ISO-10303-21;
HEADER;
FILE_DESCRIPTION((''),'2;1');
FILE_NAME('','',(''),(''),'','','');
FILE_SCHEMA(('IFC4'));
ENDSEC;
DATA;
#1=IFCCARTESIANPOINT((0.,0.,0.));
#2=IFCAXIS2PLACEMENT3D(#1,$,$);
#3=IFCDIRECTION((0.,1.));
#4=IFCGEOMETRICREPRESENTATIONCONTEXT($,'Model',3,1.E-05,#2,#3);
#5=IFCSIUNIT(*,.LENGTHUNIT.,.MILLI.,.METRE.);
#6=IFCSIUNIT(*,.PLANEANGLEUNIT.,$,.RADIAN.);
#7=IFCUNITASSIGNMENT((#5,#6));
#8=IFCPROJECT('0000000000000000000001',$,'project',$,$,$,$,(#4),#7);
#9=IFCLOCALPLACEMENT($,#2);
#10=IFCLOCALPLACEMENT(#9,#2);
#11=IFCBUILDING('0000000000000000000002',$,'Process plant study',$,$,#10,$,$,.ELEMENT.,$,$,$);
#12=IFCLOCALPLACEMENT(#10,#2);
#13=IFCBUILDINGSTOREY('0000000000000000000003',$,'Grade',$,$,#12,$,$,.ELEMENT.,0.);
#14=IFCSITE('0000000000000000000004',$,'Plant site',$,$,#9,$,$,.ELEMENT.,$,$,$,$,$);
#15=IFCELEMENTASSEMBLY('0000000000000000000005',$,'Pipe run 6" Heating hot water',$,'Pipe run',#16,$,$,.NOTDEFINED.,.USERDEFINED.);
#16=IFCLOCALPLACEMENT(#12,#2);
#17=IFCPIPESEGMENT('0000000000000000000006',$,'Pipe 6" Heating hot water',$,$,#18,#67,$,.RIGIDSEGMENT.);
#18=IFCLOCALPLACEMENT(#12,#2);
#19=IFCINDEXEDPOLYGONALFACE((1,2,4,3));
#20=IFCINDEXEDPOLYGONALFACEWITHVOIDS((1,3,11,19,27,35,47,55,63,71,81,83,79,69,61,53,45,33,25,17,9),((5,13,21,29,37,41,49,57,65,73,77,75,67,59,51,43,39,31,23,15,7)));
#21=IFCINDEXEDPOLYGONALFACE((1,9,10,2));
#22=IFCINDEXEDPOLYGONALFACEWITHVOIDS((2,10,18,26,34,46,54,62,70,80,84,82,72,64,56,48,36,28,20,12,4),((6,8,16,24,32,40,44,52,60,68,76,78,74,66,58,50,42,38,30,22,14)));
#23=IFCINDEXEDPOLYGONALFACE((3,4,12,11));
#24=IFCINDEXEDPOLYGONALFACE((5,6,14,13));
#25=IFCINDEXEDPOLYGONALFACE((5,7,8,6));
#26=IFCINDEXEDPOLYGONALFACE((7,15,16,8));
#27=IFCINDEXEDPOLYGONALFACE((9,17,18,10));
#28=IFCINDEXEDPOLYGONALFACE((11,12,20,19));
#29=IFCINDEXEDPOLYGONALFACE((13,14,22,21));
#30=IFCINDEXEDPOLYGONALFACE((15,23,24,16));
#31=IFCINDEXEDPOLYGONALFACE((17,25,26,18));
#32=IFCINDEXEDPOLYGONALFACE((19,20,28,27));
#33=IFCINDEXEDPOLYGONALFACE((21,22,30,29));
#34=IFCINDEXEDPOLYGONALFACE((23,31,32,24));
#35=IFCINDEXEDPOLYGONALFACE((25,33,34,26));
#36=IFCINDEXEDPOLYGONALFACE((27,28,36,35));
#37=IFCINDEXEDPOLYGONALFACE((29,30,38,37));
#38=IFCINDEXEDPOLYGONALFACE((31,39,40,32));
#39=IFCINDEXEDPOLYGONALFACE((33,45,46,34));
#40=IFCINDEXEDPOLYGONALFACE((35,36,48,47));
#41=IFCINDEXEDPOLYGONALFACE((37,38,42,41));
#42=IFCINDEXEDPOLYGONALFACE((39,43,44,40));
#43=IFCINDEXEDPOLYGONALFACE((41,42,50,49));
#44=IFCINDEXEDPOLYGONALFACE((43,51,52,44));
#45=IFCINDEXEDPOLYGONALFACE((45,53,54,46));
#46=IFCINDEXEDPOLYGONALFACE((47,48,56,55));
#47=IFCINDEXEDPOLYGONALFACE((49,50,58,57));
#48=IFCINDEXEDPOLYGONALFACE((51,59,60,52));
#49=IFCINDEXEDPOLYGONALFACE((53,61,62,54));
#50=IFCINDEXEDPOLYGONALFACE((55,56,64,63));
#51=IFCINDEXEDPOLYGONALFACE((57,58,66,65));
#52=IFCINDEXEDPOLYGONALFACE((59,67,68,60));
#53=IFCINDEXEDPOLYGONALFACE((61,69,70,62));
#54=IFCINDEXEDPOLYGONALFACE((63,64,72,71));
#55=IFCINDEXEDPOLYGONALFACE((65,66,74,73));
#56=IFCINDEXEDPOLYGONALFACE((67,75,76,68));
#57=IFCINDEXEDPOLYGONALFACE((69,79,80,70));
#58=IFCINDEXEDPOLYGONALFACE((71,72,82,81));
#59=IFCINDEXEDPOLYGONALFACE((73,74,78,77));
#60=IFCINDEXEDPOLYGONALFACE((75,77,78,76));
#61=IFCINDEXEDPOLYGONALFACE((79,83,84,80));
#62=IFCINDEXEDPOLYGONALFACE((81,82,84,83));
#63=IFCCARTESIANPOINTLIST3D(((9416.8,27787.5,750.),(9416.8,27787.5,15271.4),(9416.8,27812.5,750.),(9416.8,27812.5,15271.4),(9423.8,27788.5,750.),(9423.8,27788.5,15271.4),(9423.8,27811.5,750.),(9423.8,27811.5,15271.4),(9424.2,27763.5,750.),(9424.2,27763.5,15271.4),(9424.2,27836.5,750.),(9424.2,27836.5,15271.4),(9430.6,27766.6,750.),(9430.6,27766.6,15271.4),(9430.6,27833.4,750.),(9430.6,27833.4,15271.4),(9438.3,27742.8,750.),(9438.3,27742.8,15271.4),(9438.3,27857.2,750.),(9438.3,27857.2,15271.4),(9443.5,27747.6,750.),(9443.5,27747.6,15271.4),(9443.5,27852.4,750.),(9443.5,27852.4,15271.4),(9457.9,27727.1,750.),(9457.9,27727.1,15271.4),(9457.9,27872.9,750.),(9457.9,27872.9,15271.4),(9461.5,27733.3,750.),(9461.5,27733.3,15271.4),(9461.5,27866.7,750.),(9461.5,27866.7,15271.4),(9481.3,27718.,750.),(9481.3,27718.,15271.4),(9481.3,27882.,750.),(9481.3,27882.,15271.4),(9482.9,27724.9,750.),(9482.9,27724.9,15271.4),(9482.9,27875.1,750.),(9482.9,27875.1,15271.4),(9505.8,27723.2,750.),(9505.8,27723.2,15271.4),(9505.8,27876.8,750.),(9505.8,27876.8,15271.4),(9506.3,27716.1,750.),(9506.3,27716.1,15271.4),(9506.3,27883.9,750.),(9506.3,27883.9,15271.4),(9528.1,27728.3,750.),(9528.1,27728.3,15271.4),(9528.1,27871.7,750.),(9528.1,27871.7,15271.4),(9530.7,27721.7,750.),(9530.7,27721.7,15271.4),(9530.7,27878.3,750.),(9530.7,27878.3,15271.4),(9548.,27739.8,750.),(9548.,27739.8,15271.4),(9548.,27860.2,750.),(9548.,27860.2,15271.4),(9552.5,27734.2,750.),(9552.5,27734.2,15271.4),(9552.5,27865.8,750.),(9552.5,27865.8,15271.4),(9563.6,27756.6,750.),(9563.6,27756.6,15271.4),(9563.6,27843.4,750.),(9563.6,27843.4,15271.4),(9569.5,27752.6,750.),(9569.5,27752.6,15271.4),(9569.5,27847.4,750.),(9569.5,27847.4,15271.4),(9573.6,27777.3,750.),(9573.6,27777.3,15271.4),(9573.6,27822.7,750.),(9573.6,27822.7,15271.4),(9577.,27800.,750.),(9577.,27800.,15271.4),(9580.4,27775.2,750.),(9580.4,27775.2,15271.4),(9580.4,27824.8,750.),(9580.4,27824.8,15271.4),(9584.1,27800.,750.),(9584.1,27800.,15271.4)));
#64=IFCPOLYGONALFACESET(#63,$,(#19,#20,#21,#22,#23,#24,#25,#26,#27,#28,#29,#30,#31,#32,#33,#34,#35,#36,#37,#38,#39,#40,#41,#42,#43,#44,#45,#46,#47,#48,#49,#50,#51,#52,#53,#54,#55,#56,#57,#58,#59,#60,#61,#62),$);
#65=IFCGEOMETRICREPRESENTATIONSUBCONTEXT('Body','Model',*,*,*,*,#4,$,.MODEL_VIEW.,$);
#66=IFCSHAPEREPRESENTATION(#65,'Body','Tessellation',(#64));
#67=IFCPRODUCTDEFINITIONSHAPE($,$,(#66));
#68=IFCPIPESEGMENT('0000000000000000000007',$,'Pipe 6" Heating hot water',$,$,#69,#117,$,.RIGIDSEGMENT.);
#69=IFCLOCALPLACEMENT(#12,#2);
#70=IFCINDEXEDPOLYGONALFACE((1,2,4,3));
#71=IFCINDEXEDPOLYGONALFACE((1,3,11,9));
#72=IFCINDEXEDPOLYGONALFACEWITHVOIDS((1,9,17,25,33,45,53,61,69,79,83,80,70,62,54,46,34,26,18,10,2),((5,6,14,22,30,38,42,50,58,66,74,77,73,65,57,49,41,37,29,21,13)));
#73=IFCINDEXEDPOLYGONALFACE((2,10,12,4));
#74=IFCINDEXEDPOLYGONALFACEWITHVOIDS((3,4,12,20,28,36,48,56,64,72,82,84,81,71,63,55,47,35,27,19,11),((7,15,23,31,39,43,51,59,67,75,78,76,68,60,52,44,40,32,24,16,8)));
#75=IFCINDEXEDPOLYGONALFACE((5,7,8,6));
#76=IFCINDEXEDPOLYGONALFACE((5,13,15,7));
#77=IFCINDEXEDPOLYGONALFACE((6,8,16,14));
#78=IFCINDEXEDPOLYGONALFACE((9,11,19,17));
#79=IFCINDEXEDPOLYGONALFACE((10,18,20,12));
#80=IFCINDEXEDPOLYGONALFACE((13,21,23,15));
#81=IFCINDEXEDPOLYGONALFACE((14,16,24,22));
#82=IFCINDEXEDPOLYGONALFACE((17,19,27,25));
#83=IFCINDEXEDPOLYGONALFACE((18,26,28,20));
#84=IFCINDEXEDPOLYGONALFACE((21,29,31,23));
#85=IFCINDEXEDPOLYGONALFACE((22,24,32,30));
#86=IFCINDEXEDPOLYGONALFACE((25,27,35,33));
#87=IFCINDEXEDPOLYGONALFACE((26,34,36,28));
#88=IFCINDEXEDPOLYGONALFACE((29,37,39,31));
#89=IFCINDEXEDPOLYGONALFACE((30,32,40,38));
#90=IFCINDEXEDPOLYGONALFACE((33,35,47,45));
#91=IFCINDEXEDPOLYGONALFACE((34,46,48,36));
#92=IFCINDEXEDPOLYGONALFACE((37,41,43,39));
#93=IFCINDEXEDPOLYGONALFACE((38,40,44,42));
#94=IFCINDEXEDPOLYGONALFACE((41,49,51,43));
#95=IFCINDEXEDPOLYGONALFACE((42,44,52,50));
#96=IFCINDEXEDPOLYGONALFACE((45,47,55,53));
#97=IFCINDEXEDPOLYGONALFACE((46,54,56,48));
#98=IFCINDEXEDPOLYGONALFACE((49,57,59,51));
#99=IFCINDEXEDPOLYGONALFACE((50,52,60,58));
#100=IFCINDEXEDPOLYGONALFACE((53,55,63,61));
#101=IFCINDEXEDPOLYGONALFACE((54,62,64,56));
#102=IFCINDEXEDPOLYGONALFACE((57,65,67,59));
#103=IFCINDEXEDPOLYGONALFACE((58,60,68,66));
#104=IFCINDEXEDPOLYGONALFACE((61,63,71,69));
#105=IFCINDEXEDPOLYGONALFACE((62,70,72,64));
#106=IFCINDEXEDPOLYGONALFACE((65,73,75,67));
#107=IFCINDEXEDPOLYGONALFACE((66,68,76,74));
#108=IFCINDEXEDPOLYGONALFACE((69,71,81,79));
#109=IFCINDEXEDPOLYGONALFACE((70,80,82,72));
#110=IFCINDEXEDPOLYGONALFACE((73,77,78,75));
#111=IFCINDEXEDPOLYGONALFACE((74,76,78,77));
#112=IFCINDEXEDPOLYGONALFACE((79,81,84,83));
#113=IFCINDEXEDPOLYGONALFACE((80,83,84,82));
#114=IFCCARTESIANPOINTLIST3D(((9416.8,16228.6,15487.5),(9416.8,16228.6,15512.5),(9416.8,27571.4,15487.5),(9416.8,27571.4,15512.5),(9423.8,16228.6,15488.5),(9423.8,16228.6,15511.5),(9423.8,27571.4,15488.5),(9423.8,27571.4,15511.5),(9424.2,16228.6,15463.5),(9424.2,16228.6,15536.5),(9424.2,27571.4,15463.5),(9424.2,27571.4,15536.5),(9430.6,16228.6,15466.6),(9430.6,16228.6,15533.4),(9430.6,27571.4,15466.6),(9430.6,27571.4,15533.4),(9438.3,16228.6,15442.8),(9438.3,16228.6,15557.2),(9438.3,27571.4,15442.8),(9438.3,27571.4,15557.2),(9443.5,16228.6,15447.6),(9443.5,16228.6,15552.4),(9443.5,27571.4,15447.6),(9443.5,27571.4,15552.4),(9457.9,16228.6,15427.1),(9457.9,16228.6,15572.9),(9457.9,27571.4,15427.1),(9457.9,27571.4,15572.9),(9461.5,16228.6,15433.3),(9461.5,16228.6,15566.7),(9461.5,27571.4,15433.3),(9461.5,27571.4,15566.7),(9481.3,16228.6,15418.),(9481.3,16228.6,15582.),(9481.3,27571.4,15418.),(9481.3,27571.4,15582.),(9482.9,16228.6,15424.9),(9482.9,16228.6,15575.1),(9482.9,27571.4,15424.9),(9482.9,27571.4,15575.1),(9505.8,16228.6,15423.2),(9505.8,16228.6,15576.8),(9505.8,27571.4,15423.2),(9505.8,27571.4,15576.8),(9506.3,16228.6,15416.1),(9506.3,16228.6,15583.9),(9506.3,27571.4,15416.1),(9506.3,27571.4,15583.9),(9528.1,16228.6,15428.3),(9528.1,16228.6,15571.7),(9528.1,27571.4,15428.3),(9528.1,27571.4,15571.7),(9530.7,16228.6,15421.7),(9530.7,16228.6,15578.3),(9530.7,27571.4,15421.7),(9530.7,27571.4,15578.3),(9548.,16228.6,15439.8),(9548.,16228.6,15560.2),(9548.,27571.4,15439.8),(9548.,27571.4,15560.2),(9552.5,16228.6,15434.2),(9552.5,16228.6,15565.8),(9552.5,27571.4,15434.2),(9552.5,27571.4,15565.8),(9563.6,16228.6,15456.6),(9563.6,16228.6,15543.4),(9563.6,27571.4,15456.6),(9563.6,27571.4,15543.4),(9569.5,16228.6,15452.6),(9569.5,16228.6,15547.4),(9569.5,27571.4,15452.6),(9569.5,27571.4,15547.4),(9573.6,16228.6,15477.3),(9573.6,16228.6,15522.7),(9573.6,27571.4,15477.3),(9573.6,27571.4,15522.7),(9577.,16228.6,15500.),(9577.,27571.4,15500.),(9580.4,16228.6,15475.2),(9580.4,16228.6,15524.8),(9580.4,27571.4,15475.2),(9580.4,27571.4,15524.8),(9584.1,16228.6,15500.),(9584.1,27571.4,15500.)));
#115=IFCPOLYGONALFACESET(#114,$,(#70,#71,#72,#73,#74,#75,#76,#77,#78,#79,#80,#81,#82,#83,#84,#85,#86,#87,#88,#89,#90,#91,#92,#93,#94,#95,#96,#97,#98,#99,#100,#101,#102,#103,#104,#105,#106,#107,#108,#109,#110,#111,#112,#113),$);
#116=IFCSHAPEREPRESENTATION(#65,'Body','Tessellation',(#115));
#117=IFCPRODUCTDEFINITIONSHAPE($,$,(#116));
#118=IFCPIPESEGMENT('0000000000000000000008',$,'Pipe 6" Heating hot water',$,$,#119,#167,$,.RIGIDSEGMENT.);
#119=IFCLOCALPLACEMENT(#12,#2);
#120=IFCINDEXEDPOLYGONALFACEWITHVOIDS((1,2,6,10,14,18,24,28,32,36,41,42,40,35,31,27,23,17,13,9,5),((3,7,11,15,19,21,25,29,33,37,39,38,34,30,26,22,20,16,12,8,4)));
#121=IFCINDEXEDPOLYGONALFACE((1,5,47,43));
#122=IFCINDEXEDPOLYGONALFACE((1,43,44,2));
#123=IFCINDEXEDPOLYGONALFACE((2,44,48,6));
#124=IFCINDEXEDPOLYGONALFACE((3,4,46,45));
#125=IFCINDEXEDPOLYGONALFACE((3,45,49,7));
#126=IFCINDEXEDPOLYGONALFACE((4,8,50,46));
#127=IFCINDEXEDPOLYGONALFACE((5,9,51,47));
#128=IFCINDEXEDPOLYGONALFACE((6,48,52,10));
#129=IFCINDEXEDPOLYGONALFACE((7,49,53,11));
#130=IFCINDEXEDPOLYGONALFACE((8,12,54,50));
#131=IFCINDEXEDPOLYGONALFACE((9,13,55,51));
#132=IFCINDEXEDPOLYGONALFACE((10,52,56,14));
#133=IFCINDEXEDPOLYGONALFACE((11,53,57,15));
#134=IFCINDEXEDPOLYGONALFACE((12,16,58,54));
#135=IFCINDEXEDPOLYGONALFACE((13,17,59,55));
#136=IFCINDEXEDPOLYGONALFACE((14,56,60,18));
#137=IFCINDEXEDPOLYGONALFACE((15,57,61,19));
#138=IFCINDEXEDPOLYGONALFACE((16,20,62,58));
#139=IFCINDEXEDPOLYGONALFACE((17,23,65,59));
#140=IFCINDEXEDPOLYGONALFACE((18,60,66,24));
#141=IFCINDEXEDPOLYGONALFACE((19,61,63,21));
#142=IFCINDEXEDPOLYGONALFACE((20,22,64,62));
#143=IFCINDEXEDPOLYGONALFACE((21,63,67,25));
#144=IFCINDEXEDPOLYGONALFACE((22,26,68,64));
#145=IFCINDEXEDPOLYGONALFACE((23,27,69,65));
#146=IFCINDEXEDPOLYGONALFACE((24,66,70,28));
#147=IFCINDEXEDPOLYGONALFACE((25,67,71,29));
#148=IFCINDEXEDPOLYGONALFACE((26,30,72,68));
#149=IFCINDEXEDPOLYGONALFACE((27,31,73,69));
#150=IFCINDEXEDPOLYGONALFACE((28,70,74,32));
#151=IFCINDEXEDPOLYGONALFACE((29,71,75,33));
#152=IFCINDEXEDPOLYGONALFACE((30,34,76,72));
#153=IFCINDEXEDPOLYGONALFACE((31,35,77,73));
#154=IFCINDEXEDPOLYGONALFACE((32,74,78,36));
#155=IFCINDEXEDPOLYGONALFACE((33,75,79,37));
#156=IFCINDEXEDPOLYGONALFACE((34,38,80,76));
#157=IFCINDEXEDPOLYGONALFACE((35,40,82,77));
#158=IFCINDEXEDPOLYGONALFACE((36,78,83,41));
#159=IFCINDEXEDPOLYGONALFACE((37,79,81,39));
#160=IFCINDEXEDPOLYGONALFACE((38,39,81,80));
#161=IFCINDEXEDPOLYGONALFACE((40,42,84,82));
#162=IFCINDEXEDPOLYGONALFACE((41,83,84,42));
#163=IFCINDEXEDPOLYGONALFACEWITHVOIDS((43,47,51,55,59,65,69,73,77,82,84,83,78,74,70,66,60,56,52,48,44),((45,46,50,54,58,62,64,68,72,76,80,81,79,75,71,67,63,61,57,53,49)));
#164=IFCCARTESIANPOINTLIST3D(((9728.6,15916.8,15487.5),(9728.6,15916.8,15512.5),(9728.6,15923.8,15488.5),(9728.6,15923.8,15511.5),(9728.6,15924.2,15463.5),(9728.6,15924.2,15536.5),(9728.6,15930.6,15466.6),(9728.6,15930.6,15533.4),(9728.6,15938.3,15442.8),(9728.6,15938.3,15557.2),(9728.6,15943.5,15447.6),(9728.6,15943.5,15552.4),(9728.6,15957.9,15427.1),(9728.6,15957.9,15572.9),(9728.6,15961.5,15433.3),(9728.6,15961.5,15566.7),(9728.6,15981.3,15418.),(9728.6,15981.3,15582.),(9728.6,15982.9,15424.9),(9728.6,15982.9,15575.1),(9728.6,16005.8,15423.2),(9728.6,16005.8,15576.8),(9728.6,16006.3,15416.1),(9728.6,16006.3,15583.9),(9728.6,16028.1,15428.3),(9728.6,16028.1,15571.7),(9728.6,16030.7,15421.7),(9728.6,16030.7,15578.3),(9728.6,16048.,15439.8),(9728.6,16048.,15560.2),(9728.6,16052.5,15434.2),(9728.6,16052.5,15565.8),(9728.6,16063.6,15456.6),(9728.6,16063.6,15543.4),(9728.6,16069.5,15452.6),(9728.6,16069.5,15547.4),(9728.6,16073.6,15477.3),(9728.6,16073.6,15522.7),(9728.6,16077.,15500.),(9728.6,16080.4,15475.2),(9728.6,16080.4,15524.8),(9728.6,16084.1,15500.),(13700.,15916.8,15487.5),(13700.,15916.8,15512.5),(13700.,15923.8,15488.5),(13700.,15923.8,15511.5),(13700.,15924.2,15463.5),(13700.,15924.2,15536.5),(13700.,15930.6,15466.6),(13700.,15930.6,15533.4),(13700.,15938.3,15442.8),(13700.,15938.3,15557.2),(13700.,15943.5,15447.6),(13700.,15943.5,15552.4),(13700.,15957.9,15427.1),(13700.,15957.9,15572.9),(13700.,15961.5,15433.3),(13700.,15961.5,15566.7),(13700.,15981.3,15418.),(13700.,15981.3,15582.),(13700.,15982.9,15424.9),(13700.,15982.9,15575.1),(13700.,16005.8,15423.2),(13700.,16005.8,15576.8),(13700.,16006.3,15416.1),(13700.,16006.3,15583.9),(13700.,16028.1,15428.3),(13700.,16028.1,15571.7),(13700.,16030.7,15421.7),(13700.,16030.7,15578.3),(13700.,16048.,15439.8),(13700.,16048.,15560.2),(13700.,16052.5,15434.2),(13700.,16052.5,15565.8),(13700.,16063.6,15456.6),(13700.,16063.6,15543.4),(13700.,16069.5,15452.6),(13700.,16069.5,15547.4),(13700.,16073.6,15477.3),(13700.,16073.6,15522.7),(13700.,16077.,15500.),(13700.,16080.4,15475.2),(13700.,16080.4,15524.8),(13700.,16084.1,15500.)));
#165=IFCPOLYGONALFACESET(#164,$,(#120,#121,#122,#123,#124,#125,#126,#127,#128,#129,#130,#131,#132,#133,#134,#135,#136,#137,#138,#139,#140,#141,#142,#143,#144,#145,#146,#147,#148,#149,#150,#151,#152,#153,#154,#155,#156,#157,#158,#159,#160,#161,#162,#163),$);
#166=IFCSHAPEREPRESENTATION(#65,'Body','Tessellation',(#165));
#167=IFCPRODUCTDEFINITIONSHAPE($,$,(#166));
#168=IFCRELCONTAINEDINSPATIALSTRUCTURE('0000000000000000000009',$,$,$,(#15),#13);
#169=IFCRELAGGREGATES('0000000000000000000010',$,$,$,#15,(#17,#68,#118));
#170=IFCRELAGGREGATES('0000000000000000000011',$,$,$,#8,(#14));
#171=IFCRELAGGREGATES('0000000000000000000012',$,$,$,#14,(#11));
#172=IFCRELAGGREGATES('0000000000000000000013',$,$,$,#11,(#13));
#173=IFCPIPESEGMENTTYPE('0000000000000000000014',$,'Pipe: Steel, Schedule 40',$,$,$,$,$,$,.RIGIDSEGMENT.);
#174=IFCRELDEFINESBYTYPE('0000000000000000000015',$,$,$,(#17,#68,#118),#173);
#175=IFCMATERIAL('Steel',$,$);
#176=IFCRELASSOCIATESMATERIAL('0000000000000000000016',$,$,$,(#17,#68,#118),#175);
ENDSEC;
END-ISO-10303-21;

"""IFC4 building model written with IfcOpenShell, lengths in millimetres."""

from ifc_helpers import new_model, si_unit, direction, frame, origin, origin_with_axes, origin_2d, place, context, subcontext, project, spatial, hollow_circle, extrude, material, type_object, element, aggregate, save


model = new_model("IFC4")

# Units and contexts
model_context = context("Model", 3, precision=1e-05, world=origin(), true_north=direction((0.0, 1.0)))
body_context = subcontext(model_context, "Body", "Model", "MODEL_VIEW")
ifc_project = project(units=[si_unit("LENGTHUNIT", "METRE", prefix="MILLI"), si_unit("PLANEANGLEUNIT", "RADIAN")], contexts=[model_context])

# Site, building, storey
site_placement = place(None, origin())
site = spatial("IfcSite", under=ifc_project, at=site_placement, Name="Plant site", CompositionType="ELEMENT")
building_placement = place(site_placement, origin())
building = spatial("IfcBuilding", under=site, at=building_placement, Name="Process plant study", CompositionType="ELEMENT")
storey_placement = place(building_placement, origin())
storey = spatial("IfcBuildingStorey", under=building, at=storey_placement, Name="Grade", CompositionType="ELEMENT", Elevation=0.0)

# Element assembly, pipe segments
assembly_1_placement = place(storey_placement, origin_with_axes())
assembly_1 = element("IfcElementAssembly", 1, at=assembly_1_placement, inside=storey, Name="Pipe run 6\" Heating hot water", ObjectType="Pipe run", AssemblyPlace="NOTDEFINED", PredefinedType="USERDEFINED")
ifc_material = material(Name="Steel")
pipe_segment_type = type_object("IfcPipeSegmentType", Name="Pipe: Steel, Schedule 40", PredefinedType="RIGIDSEGMENT")
pipe_segment_1_placement = place(storey_placement, origin_with_axes())
pipe_segment_1 = element("IfcPipeSegment", 2, at=pipe_segment_1_placement, type_object=pipe_segment_type, material=ifc_material, Name="Pipe 6\" Heating hot water", PredefinedType="RIGIDSEGMENT", context=body_context, shape_type="SweptSolid", body=[
    extrude(hollow_circle(Radius=84.1, WallThickness=7.1, at=origin_2d()), frame((9500.0, 27800.0, 750.0), z_axis=(0.0, 0.0, 1.0), x_axis=(1.0, 0.0, 0.0)), (0.0, 0.0, 1.0), 14521.4),
])
pipe_segment_2_placement = place(storey_placement, origin_with_axes())
pipe_segment_2 = element("IfcPipeSegment", 3, at=pipe_segment_2_placement, type_object=pipe_segment_type, material=ifc_material, Name="Pipe 6\" Heating hot water", PredefinedType="RIGIDSEGMENT", context=body_context, shape_type="SweptSolid", body=[
    extrude(hollow_circle(Radius=84.1, WallThickness=7.1, at=origin_2d()), frame((9500.0, 27571.4, 15500.0), z_axis=(0.0, -1.0, 0.0), x_axis=(1.0, 0.0, 0.0)), (0.0, 0.0, 1.0), 11342.8),
])
pipe_segment_3_placement = place(storey_placement, origin_with_axes())
pipe_segment_3 = element("IfcPipeSegment", 4, at=pipe_segment_3_placement, type_object=pipe_segment_type, material=ifc_material, Name="Pipe 6\" Heating hot water", PredefinedType="RIGIDSEGMENT", context=body_context, shape_type="SweptSolid", body=[
    extrude(hollow_circle(Radius=84.1, WallThickness=7.1, at=origin_2d()), frame((9728.6, 16000.0, 15500.0), z_axis=(1.0, 0.0, 0.0), x_axis=(0.0, 1.0, 0.0)), (0.0, 0.0, 1.0), 3971.4),
])

aggregate(assembly_1, [pipe_segment_1, pipe_segment_2, pipe_segment_3])

save(model, "model.ifc")
